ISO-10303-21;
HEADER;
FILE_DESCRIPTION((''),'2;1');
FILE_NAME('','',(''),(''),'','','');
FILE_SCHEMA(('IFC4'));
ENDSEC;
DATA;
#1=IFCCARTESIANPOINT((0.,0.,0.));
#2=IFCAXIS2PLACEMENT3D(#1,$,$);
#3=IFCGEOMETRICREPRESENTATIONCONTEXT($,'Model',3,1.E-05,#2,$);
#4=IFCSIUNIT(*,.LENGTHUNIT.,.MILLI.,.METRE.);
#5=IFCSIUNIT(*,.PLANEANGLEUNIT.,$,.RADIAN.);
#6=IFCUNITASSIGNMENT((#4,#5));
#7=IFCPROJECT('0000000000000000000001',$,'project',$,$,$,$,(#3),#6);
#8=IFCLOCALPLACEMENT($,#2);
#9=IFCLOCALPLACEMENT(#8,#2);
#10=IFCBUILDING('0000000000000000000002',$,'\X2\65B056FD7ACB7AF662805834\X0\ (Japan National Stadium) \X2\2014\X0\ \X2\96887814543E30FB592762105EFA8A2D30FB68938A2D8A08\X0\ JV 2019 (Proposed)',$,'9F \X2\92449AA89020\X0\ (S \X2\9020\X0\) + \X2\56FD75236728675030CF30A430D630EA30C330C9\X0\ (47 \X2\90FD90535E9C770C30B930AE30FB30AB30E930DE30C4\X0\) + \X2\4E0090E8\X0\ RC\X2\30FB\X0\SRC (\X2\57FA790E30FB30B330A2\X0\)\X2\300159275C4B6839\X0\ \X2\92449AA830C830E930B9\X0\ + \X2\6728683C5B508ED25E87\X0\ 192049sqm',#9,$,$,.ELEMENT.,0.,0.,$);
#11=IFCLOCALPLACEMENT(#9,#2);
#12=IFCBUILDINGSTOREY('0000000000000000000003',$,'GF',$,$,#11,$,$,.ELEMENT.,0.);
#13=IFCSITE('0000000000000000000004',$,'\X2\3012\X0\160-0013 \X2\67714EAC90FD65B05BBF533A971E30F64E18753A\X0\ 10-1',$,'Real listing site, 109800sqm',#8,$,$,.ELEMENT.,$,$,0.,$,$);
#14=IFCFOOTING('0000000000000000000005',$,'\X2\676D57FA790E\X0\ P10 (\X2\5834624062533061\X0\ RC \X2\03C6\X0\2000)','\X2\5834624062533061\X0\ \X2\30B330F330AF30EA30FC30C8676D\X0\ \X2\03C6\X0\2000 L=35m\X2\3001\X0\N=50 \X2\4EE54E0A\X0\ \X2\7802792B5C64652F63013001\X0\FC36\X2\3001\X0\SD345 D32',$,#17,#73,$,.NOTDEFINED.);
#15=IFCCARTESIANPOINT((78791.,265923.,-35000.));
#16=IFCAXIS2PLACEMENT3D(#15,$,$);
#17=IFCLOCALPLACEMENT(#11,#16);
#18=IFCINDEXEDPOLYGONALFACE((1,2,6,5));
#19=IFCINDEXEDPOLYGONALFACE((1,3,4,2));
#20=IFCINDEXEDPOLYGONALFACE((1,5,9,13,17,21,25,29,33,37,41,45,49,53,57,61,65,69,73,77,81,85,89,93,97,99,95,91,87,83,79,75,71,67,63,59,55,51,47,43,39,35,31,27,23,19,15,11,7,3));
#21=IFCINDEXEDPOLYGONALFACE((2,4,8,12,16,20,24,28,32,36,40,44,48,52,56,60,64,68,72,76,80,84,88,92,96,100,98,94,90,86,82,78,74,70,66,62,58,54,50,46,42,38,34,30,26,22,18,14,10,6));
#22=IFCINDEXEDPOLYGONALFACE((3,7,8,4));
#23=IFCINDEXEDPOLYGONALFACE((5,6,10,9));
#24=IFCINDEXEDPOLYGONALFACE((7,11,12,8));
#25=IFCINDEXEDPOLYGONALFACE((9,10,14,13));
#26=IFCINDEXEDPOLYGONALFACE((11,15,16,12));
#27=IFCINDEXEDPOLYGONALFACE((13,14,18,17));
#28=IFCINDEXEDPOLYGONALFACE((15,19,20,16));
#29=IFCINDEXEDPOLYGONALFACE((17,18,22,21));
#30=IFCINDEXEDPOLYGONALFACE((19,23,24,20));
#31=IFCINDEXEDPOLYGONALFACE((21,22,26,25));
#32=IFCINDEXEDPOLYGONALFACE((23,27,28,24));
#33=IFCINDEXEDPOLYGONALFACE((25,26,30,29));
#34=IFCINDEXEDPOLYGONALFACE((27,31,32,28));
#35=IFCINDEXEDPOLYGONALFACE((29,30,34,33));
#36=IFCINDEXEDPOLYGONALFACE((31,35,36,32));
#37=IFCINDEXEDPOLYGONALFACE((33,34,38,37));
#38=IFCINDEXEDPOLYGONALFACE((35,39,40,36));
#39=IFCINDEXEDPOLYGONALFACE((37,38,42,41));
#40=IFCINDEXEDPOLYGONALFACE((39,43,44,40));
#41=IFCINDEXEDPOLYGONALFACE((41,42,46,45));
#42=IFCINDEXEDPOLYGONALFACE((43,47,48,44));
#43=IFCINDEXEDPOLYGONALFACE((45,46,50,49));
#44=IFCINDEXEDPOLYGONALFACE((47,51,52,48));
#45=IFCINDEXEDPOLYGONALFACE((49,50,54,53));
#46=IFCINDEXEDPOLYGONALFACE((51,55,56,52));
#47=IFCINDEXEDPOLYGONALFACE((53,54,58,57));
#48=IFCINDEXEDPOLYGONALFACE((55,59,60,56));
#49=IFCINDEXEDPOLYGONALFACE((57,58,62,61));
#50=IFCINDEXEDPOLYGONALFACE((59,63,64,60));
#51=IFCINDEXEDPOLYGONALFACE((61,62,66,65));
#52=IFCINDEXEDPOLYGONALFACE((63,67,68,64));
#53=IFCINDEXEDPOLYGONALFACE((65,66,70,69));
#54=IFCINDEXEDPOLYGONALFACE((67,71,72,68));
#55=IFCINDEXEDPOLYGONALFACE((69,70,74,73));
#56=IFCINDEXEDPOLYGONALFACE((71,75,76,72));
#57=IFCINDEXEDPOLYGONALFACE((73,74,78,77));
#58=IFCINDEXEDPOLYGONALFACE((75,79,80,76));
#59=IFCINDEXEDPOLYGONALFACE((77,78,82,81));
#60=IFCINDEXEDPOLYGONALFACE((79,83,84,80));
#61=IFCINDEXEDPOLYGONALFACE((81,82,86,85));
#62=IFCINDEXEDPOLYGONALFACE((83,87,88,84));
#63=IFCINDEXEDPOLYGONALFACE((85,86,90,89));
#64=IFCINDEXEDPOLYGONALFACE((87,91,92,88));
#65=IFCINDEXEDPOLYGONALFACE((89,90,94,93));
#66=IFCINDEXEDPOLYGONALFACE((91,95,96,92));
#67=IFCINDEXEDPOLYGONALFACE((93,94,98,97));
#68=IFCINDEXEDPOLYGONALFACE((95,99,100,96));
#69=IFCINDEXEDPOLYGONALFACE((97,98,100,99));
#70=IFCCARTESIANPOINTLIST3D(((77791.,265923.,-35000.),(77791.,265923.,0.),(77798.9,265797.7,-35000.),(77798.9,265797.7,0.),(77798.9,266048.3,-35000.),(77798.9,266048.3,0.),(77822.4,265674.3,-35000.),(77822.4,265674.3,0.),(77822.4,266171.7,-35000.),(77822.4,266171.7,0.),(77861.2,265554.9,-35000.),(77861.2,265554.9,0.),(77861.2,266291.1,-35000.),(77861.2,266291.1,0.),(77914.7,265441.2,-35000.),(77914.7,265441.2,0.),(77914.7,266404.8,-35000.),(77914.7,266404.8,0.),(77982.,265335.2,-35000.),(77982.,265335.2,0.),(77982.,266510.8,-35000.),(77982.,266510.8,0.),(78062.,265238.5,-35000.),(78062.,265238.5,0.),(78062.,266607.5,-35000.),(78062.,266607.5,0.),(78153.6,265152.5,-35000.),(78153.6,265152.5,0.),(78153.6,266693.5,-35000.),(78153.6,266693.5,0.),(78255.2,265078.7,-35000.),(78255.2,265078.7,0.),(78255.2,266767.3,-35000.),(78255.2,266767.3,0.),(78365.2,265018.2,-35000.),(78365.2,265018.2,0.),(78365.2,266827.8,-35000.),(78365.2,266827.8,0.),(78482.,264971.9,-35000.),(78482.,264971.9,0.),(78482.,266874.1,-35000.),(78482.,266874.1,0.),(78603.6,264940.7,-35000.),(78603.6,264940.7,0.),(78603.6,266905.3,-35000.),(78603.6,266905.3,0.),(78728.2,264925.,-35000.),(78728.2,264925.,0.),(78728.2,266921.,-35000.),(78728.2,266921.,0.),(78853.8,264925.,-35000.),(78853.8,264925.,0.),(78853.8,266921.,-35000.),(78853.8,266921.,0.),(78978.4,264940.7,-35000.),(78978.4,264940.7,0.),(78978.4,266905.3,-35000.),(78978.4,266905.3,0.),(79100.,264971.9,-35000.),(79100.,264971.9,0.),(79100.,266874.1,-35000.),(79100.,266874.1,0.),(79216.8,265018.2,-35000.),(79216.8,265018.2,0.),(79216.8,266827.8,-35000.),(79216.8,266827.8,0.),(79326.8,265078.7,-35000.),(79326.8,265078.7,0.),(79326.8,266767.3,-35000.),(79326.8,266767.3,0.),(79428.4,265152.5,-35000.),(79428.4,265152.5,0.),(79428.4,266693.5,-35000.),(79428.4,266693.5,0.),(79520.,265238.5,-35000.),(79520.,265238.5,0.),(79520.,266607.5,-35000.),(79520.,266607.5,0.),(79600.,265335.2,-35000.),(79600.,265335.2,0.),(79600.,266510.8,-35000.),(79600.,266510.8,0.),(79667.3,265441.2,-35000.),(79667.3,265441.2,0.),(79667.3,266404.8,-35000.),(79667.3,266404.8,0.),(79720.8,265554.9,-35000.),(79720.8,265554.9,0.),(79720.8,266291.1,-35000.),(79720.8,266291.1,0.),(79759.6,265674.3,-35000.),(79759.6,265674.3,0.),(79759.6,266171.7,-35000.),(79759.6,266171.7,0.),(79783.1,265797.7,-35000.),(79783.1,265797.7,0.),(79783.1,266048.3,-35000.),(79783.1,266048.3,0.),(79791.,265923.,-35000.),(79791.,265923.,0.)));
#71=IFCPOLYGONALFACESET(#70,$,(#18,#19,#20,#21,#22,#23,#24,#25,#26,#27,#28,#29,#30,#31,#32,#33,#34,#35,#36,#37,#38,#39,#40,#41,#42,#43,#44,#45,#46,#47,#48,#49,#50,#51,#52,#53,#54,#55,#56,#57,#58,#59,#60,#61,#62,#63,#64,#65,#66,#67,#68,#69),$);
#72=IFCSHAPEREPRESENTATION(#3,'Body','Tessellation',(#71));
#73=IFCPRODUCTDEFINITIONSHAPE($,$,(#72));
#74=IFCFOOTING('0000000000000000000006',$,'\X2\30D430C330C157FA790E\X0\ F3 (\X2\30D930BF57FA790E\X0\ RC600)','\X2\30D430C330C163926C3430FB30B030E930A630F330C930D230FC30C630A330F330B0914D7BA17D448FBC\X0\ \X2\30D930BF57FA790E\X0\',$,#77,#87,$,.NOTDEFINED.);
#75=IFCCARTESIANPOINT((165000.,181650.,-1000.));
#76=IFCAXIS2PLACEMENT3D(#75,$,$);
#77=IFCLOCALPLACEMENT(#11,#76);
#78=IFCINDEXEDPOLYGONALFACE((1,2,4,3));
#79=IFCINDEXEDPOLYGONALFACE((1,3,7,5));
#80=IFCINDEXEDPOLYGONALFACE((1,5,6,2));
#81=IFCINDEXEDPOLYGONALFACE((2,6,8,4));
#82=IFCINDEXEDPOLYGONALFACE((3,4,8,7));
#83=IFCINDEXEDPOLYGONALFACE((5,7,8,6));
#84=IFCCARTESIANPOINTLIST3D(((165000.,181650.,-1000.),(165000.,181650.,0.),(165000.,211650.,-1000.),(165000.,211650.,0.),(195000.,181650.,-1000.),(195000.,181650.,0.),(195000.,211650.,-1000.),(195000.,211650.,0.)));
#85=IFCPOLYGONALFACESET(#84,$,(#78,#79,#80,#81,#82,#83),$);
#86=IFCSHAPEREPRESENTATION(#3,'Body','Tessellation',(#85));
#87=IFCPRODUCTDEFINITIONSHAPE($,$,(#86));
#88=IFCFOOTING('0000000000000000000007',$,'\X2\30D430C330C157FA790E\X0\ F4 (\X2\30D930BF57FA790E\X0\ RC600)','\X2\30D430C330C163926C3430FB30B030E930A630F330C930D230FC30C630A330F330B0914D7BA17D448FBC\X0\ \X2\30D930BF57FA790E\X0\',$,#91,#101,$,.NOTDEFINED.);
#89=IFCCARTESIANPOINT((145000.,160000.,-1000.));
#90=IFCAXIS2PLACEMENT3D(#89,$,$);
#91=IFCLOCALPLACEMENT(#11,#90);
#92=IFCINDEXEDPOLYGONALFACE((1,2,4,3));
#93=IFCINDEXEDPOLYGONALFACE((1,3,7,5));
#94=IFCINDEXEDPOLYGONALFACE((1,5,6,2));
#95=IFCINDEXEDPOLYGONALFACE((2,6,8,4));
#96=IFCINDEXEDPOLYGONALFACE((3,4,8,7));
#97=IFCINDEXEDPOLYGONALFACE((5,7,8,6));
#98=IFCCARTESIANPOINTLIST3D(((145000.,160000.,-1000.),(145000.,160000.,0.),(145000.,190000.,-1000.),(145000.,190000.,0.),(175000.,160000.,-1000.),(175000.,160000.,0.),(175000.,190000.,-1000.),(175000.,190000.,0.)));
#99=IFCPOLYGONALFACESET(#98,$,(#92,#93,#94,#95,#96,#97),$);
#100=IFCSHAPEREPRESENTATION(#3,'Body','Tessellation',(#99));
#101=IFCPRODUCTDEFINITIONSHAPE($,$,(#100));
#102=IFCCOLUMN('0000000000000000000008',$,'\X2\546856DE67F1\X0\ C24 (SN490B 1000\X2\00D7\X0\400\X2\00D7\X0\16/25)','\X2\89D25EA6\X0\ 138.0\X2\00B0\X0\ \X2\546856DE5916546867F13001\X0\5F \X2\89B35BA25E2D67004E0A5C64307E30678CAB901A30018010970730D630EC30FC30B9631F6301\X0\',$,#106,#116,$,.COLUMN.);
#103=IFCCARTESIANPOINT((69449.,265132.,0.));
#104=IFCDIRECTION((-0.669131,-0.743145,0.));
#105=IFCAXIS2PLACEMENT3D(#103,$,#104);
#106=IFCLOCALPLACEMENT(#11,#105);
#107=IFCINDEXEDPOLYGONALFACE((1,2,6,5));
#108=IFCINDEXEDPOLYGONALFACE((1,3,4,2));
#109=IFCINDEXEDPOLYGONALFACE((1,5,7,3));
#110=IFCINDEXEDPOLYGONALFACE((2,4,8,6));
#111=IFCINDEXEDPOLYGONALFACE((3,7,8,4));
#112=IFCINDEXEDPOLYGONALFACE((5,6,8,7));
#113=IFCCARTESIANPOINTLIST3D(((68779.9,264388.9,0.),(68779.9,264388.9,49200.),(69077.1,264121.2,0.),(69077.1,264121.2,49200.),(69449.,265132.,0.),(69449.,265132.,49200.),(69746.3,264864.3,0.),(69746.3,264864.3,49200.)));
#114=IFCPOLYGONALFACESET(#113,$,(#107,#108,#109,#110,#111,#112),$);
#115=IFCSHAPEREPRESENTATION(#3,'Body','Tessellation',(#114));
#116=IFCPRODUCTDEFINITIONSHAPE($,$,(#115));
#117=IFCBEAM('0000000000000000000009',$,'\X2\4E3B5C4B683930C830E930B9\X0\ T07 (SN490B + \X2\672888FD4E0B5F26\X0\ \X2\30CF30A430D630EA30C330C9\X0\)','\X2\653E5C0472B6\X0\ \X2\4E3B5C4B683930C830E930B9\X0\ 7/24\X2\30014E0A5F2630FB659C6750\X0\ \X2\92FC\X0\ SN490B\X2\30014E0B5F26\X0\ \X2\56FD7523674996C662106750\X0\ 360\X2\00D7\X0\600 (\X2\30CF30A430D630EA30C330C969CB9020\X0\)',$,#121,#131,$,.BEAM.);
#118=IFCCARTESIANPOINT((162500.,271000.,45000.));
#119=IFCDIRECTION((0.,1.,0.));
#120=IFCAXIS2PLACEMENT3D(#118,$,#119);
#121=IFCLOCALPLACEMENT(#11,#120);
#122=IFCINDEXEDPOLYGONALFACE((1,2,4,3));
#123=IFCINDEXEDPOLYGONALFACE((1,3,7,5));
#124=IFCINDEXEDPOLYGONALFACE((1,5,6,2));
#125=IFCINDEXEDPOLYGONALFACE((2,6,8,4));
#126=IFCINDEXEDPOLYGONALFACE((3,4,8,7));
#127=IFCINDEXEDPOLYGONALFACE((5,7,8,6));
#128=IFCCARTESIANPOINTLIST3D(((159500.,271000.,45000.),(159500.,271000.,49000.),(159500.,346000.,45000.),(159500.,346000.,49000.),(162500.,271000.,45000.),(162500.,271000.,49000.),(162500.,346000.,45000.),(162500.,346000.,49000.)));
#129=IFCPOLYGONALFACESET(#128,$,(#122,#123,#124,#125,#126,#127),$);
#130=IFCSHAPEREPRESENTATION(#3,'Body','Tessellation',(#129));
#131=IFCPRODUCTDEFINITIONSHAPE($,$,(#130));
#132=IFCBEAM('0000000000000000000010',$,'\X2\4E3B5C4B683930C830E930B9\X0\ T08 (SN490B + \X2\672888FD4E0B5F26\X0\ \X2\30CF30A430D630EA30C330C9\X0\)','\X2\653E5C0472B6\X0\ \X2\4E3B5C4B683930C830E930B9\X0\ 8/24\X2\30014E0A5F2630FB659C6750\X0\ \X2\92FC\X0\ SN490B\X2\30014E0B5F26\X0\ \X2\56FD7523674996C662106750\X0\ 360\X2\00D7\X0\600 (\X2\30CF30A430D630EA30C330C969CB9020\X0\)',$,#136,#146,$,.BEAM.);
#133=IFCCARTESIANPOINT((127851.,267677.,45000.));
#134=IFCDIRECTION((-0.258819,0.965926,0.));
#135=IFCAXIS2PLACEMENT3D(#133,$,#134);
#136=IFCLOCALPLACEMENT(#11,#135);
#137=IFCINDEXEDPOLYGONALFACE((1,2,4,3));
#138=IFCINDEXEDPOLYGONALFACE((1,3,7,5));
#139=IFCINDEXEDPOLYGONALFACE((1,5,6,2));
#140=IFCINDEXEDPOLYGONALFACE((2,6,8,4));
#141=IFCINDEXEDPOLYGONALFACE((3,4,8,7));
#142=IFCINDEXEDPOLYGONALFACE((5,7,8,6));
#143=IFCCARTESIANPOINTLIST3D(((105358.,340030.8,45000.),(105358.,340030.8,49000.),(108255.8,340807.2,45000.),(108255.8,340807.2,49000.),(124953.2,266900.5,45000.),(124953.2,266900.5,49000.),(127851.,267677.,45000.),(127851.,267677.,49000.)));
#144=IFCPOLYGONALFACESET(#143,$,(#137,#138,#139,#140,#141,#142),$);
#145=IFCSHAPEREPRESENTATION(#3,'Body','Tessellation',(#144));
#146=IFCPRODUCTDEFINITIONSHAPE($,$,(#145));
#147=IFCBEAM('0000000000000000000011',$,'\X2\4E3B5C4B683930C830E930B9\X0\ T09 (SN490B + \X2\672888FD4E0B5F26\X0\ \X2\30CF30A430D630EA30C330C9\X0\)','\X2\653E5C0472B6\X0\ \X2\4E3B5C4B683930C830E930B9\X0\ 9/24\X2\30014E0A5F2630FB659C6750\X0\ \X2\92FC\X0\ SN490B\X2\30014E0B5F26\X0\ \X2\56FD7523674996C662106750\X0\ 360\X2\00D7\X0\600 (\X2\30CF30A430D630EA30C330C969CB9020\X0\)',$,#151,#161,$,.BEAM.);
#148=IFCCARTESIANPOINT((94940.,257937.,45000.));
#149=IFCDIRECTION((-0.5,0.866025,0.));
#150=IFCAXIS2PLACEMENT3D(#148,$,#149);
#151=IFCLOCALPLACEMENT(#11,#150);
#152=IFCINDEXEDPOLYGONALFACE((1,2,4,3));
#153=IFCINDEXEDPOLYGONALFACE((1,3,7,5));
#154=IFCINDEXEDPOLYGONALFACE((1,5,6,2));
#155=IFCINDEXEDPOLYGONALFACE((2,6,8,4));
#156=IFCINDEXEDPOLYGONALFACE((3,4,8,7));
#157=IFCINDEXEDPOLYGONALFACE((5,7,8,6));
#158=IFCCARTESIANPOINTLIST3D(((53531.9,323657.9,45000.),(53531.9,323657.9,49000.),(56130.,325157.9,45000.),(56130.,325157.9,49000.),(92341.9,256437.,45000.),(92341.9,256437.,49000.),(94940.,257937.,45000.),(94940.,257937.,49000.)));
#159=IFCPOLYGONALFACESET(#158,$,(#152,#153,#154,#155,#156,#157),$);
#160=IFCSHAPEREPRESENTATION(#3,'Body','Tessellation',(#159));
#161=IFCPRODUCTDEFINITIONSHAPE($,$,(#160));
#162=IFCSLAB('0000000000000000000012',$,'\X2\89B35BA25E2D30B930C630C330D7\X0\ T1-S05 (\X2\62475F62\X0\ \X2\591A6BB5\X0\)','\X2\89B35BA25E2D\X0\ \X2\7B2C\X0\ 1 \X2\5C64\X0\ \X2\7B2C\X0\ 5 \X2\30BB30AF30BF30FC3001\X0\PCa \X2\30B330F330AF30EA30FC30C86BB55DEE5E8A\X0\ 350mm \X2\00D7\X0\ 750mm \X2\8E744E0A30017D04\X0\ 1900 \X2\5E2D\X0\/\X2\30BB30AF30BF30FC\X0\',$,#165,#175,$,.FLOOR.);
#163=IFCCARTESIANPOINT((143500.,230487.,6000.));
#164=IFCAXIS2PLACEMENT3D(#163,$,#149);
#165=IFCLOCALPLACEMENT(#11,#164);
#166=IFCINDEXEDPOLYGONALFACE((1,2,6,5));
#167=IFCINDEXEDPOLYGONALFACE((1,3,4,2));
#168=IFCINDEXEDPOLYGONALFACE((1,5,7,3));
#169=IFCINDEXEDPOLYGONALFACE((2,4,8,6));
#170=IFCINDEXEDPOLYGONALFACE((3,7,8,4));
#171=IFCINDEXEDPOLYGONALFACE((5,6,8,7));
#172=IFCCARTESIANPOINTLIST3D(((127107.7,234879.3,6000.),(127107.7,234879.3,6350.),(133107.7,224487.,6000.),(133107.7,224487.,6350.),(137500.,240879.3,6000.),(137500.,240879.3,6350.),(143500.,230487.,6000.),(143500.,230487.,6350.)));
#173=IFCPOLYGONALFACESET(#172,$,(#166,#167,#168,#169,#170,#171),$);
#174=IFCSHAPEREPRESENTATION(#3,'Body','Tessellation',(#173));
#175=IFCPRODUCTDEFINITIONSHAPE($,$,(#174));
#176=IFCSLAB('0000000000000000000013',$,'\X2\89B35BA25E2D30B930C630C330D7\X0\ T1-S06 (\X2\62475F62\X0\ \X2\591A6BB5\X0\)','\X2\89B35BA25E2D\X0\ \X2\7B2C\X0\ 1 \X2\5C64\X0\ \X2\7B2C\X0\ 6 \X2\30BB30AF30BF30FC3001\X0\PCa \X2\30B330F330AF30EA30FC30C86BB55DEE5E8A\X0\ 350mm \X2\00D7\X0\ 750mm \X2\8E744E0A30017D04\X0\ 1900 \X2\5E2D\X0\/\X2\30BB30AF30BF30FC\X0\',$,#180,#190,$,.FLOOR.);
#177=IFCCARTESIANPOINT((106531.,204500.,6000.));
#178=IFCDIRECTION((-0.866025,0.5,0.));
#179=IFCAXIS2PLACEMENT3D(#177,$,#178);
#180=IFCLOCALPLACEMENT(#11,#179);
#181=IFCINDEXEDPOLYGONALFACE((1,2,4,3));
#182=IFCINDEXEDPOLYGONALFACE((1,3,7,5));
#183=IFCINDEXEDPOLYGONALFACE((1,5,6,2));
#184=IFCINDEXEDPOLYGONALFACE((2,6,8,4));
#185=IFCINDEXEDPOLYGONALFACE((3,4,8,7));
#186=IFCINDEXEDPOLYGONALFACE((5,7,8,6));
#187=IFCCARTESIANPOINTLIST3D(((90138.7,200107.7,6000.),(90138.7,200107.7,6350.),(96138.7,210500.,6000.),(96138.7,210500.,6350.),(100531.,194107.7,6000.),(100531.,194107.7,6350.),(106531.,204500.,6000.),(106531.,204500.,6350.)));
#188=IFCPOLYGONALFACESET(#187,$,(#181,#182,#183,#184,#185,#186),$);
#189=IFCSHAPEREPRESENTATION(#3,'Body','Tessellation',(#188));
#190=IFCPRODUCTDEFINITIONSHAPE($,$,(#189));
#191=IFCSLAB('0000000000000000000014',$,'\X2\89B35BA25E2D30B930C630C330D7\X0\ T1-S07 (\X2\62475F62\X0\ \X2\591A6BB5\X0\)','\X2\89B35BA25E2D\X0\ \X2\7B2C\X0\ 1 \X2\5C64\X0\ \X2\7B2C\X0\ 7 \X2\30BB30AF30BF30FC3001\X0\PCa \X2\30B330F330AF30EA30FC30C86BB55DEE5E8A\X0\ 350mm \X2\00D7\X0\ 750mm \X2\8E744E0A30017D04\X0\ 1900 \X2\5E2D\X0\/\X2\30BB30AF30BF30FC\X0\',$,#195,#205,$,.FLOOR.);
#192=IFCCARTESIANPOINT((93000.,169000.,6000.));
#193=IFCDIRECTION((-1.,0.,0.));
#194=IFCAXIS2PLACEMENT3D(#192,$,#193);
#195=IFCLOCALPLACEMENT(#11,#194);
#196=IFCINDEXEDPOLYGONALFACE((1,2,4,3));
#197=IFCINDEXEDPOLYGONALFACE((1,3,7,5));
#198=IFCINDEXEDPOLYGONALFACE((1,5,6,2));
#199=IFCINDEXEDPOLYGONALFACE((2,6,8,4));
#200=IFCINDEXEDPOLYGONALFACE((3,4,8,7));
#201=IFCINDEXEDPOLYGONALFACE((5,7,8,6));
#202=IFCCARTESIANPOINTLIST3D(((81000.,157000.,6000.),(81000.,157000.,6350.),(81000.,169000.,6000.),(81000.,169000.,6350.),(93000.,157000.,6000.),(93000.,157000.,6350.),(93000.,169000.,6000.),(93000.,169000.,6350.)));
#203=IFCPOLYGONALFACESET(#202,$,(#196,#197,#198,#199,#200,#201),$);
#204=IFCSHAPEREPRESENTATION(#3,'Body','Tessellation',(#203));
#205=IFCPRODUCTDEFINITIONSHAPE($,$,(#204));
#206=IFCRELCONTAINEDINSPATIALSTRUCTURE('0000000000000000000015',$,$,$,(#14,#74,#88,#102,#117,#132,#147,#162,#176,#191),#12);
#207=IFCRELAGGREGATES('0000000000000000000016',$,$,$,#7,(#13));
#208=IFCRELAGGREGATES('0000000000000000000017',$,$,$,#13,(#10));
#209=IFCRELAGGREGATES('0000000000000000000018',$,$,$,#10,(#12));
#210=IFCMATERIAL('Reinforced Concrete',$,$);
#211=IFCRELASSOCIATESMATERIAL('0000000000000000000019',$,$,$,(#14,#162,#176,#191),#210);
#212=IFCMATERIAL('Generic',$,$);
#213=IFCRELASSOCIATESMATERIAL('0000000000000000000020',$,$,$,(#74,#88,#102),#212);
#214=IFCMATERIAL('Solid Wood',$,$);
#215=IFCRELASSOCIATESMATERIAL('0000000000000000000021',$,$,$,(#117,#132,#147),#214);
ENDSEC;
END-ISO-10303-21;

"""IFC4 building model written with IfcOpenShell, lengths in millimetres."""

from ifc_helpers import new_model, si_unit, frame, frame_2d, origin, origin_2d, place, context, project, spatial, rectangle, circle, extrude, material, element, save


model = new_model("IFC4")

# Units and contexts
model_context = context("Model", 3, precision=1e-05, world=origin())
ifc_project = project(units=[si_unit("LENGTHUNIT", "METRE", prefix="MILLI"), si_unit("PLANEANGLEUNIT", "RADIAN")], contexts=[model_context])

# Site, building, storey
site_placement = place(None, origin())
site = spatial("IfcSite", under=ifc_project, at=site_placement, Name="〒160-0013 東京都新宿区霞ヶ丘町 10-1", ObjectType="Real listing site, 109800sqm", CompositionType="ELEMENT", RefElevation=0.0)
building_placement = place(site_placement, origin())
building = spatial("IfcBuilding", under=site, at=building_placement, Name="新国立競技場 (Japan National Stadium) — 隈研吾・大成建設・梓設計 JV 2019 (Proposed)", ObjectType="9F 鉄骨造 (S 造) + 国産木材ハイブリッド (47 都道府県スギ・カラマツ) + 一部 RC・SRC (基礎・コア)、大屋根 鉄骨トラス + 木格子軒庇 192049sqm", CompositionType="ELEMENT", ElevationOfRefHeight=0.0, ElevationOfTerrain=0.0)
storey_placement = place(building_placement, origin())
storey = spatial("IfcBuildingStorey", under=building, at=storey_placement, Name="GF", CompositionType="ELEMENT", Elevation=0.0)

# Footings
ifc_material_1 = material(Name="Reinforced Concrete")
footing_1_placement = place(storey_placement, frame((78791.0, 265923.0, -35000.0)))
element("IfcFooting", 1, at=footing_1_placement, inside=storey, material=ifc_material_1, Name="杭基礎 P10 (場所打ち RC φ2000)", Description="場所打ち コンクリート杭 φ2000 L=35m、N=50 以上 砂礫層支持、FC36、SD345 D32", PredefinedType="NOTDEFINED", context=model_context, shape_type="SweptSolid", body=[
    extrude(circle(Radius=1000.0, at=origin_2d()), frame((78791.0, 265923.0, -35000.0)), (0.0, 0.0, 1.0), 35000.0),
])
ifc_material_2 = material(Name="Generic")
footing_2_placement = place(storey_placement, frame((165000.0, 181650.0, -1000.0)))
element("IfcFooting", 2, at=footing_2_placement, inside=storey, material=ifc_material_2, Name="ピッチ基礎 F3 (ベタ基礎 RC600)", Description="ピッチ排水・グラウンドヒーティング配管組込 ベタ基礎", PredefinedType="NOTDEFINED", context=model_context, shape_type="SweptSolid", body=[
    extrude(rectangle(XDim=30000.0, YDim=30000.0, at=frame_2d((15000.0, 15000.0))), frame((165000.0, 181650.0, -1000.0)), (0.0, 0.0, 1.0), 1000.0),
])
footing_3_placement = place(storey_placement, frame((145000.0, 160000.0, -1000.0)))
element("IfcFooting", 3, at=footing_3_placement, inside=storey, material=ifc_material_2, Name="ピッチ基礎 F4 (ベタ基礎 RC600)", Description="ピッチ排水・グラウンドヒーティング配管組込 ベタ基礎", PredefinedType="NOTDEFINED", context=model_context, shape_type="SweptSolid", body=[
    extrude(rectangle(XDim=30000.0, YDim=30000.0, at=frame_2d((15000.0, 15000.0))), frame((145000.0, 160000.0, -1000.0)), (0.0, 0.0, 1.0), 1000.0),
])

# Column
column_placement = place(storey_placement, frame((69449.0, 265132.0, 0.0), x_axis=(-0.669131, -0.743145, 0.0)))
element("IfcColumn", 4, at=column_placement, inside=storey, material=ifc_material_2, Name="周回柱 C24 (SN490B 1000×400×16/25)", Description="角度 138.0° 周回外周柱、5F 観客席最上層まで貫通、耐震ブレース挟持", PredefinedType="COLUMN", context=model_context, shape_type="SweptSolid", body=[
    extrude(rectangle(XDim=1000.0, YDim=400.0, at=frame_2d((500.0, 200.0))), frame((69449.0, 265132.0, 0.0), x_axis=(-0.669131, -0.743145, 0.0)), (0.0, 0.0, 1.0), 49200.0),
])

# Beams
ifc_material_3 = material(Name="Solid Wood")
beam_1_placement = place(storey_placement, frame((162500.0, 271000.0, 45000.0), x_axis=(0.0, 1.0, 0.0)))
element("IfcBeam", 5, at=beam_1_placement, inside=storey, material=ifc_material_3, Name="主屋根トラス T07 (SN490B + 木製下弦 ハイブリッド)", Description="放射状 主屋根トラス 7/24、上弦・斜材 鋼 SN490B、下弦 国産杉集成材 360×600 (ハイブリッド構造)", PredefinedType="BEAM", context=model_context, shape_type="SweptSolid", body=[
    extrude(rectangle(XDim=75000.0, YDim=3000.0, at=frame_2d((37500.0, 1500.0))), frame((162500.0, 271000.0, 45000.0), x_axis=(0.0, 1.0, 0.0)), (0.0, 0.0, 1.0), 4000.0),
])
beam_2_placement = place(storey_placement, frame((127851.0, 267677.0, 45000.0), x_axis=(-0.258819, 0.965926, 0.0)))
element("IfcBeam", 6, at=beam_2_placement, inside=storey, material=ifc_material_3, Name="主屋根トラス T08 (SN490B + 木製下弦 ハイブリッド)", Description="放射状 主屋根トラス 8/24、上弦・斜材 鋼 SN490B、下弦 国産杉集成材 360×600 (ハイブリッド構造)", PredefinedType="BEAM", context=model_context, shape_type="SweptSolid", body=[
    extrude(rectangle(XDim=75710.0, YDim=3000.0, at=frame_2d((37855.0, 1500.0))), frame((127851.0, 267677.0, 45000.0), x_axis=(-0.258819, 0.965926, 0.0)), (0.0, 0.0, 1.0), 4000.0),
])
beam_3_placement = place(storey_placement, frame((94940.0, 257937.0, 45000.0), x_axis=(-0.5, 0.866025, 0.0)))
element("IfcBeam", 7, at=beam_3_placement, inside=storey, material=ifc_material_3, Name="主屋根トラス T09 (SN490B + 木製下弦 ハイブリッド)", Description="放射状 主屋根トラス 9/24、上弦・斜材 鋼 SN490B、下弦 国産杉集成材 360×600 (ハイブリッド構造)", PredefinedType="BEAM", context=model_context, shape_type="SweptSolid", body=[
    extrude(rectangle(XDim=77620.0, YDim=3000.0, at=frame_2d((38810.0, 1500.0))), frame((94940.0, 257937.0, 45000.0), x_axis=(-0.5, 0.866025, 0.0)), (0.0, 0.0, 1.0), 4000.0),
])

# Slabs
slab_1_placement = place(storey_placement, frame((143500.0, 230487.0, 6000.0), x_axis=(-0.5, 0.866025, 0.0)))
element("IfcSlab", 8, at=slab_1_placement, inside=storey, material=ifc_material_1, Name="観客席ステップ T1-S05 (扇形 多段)", Description="観客席 第 1 層 第 5 セクター、PCa コンクリート段差床 350mm × 750mm 蹴上、約 1900 席/セクター", PredefinedType="FLOOR", context=model_context, shape_type="SweptSolid", body=[
    extrude(rectangle(XDim=12000.0, YDim=12000.0, at=frame_2d((6000.0, 6000.0))), frame((143500.0, 230487.0, 6000.0), x_axis=(-0.5, 0.866025, 0.0)), (0.0, 0.0, 1.0), 350.0),
])
slab_2_placement = place(storey_placement, frame((106531.0, 204500.0, 6000.0), x_axis=(-0.866025, 0.5, 0.0)))
element("IfcSlab", 9, at=slab_2_placement, inside=storey, material=ifc_material_1, Name="観客席ステップ T1-S06 (扇形 多段)", Description="観客席 第 1 層 第 6 セクター、PCa コンクリート段差床 350mm × 750mm 蹴上、約 1900 席/セクター", PredefinedType="FLOOR", context=model_context, shape_type="SweptSolid", body=[
    extrude(rectangle(XDim=12000.0, YDim=12000.0, at=frame_2d((6000.0, 6000.0))), frame((106531.0, 204500.0, 6000.0), x_axis=(-0.866025, 0.5, 0.0)), (0.0, 0.0, 1.0), 350.0),
])
slab_3_placement = place(storey_placement, frame((93000.0, 169000.0, 6000.0), x_axis=(-1.0, 0.0, 0.0)))
element("IfcSlab", 10, at=slab_3_placement, inside=storey, material=ifc_material_1, Name="観客席ステップ T1-S07 (扇形 多段)", Description="観客席 第 1 層 第 7 セクター、PCa コンクリート段差床 350mm × 750mm 蹴上、約 1900 席/セクター", PredefinedType="FLOOR", context=model_context, shape_type="SweptSolid", body=[
    extrude(rectangle(XDim=12000.0, YDim=12000.0, at=frame_2d((6000.0, 6000.0))), frame((93000.0, 169000.0, 6000.0), x_axis=(-1.0, 0.0, 0.0)), (0.0, 0.0, 1.0), 350.0),
])

save(model, "model.ifc")
